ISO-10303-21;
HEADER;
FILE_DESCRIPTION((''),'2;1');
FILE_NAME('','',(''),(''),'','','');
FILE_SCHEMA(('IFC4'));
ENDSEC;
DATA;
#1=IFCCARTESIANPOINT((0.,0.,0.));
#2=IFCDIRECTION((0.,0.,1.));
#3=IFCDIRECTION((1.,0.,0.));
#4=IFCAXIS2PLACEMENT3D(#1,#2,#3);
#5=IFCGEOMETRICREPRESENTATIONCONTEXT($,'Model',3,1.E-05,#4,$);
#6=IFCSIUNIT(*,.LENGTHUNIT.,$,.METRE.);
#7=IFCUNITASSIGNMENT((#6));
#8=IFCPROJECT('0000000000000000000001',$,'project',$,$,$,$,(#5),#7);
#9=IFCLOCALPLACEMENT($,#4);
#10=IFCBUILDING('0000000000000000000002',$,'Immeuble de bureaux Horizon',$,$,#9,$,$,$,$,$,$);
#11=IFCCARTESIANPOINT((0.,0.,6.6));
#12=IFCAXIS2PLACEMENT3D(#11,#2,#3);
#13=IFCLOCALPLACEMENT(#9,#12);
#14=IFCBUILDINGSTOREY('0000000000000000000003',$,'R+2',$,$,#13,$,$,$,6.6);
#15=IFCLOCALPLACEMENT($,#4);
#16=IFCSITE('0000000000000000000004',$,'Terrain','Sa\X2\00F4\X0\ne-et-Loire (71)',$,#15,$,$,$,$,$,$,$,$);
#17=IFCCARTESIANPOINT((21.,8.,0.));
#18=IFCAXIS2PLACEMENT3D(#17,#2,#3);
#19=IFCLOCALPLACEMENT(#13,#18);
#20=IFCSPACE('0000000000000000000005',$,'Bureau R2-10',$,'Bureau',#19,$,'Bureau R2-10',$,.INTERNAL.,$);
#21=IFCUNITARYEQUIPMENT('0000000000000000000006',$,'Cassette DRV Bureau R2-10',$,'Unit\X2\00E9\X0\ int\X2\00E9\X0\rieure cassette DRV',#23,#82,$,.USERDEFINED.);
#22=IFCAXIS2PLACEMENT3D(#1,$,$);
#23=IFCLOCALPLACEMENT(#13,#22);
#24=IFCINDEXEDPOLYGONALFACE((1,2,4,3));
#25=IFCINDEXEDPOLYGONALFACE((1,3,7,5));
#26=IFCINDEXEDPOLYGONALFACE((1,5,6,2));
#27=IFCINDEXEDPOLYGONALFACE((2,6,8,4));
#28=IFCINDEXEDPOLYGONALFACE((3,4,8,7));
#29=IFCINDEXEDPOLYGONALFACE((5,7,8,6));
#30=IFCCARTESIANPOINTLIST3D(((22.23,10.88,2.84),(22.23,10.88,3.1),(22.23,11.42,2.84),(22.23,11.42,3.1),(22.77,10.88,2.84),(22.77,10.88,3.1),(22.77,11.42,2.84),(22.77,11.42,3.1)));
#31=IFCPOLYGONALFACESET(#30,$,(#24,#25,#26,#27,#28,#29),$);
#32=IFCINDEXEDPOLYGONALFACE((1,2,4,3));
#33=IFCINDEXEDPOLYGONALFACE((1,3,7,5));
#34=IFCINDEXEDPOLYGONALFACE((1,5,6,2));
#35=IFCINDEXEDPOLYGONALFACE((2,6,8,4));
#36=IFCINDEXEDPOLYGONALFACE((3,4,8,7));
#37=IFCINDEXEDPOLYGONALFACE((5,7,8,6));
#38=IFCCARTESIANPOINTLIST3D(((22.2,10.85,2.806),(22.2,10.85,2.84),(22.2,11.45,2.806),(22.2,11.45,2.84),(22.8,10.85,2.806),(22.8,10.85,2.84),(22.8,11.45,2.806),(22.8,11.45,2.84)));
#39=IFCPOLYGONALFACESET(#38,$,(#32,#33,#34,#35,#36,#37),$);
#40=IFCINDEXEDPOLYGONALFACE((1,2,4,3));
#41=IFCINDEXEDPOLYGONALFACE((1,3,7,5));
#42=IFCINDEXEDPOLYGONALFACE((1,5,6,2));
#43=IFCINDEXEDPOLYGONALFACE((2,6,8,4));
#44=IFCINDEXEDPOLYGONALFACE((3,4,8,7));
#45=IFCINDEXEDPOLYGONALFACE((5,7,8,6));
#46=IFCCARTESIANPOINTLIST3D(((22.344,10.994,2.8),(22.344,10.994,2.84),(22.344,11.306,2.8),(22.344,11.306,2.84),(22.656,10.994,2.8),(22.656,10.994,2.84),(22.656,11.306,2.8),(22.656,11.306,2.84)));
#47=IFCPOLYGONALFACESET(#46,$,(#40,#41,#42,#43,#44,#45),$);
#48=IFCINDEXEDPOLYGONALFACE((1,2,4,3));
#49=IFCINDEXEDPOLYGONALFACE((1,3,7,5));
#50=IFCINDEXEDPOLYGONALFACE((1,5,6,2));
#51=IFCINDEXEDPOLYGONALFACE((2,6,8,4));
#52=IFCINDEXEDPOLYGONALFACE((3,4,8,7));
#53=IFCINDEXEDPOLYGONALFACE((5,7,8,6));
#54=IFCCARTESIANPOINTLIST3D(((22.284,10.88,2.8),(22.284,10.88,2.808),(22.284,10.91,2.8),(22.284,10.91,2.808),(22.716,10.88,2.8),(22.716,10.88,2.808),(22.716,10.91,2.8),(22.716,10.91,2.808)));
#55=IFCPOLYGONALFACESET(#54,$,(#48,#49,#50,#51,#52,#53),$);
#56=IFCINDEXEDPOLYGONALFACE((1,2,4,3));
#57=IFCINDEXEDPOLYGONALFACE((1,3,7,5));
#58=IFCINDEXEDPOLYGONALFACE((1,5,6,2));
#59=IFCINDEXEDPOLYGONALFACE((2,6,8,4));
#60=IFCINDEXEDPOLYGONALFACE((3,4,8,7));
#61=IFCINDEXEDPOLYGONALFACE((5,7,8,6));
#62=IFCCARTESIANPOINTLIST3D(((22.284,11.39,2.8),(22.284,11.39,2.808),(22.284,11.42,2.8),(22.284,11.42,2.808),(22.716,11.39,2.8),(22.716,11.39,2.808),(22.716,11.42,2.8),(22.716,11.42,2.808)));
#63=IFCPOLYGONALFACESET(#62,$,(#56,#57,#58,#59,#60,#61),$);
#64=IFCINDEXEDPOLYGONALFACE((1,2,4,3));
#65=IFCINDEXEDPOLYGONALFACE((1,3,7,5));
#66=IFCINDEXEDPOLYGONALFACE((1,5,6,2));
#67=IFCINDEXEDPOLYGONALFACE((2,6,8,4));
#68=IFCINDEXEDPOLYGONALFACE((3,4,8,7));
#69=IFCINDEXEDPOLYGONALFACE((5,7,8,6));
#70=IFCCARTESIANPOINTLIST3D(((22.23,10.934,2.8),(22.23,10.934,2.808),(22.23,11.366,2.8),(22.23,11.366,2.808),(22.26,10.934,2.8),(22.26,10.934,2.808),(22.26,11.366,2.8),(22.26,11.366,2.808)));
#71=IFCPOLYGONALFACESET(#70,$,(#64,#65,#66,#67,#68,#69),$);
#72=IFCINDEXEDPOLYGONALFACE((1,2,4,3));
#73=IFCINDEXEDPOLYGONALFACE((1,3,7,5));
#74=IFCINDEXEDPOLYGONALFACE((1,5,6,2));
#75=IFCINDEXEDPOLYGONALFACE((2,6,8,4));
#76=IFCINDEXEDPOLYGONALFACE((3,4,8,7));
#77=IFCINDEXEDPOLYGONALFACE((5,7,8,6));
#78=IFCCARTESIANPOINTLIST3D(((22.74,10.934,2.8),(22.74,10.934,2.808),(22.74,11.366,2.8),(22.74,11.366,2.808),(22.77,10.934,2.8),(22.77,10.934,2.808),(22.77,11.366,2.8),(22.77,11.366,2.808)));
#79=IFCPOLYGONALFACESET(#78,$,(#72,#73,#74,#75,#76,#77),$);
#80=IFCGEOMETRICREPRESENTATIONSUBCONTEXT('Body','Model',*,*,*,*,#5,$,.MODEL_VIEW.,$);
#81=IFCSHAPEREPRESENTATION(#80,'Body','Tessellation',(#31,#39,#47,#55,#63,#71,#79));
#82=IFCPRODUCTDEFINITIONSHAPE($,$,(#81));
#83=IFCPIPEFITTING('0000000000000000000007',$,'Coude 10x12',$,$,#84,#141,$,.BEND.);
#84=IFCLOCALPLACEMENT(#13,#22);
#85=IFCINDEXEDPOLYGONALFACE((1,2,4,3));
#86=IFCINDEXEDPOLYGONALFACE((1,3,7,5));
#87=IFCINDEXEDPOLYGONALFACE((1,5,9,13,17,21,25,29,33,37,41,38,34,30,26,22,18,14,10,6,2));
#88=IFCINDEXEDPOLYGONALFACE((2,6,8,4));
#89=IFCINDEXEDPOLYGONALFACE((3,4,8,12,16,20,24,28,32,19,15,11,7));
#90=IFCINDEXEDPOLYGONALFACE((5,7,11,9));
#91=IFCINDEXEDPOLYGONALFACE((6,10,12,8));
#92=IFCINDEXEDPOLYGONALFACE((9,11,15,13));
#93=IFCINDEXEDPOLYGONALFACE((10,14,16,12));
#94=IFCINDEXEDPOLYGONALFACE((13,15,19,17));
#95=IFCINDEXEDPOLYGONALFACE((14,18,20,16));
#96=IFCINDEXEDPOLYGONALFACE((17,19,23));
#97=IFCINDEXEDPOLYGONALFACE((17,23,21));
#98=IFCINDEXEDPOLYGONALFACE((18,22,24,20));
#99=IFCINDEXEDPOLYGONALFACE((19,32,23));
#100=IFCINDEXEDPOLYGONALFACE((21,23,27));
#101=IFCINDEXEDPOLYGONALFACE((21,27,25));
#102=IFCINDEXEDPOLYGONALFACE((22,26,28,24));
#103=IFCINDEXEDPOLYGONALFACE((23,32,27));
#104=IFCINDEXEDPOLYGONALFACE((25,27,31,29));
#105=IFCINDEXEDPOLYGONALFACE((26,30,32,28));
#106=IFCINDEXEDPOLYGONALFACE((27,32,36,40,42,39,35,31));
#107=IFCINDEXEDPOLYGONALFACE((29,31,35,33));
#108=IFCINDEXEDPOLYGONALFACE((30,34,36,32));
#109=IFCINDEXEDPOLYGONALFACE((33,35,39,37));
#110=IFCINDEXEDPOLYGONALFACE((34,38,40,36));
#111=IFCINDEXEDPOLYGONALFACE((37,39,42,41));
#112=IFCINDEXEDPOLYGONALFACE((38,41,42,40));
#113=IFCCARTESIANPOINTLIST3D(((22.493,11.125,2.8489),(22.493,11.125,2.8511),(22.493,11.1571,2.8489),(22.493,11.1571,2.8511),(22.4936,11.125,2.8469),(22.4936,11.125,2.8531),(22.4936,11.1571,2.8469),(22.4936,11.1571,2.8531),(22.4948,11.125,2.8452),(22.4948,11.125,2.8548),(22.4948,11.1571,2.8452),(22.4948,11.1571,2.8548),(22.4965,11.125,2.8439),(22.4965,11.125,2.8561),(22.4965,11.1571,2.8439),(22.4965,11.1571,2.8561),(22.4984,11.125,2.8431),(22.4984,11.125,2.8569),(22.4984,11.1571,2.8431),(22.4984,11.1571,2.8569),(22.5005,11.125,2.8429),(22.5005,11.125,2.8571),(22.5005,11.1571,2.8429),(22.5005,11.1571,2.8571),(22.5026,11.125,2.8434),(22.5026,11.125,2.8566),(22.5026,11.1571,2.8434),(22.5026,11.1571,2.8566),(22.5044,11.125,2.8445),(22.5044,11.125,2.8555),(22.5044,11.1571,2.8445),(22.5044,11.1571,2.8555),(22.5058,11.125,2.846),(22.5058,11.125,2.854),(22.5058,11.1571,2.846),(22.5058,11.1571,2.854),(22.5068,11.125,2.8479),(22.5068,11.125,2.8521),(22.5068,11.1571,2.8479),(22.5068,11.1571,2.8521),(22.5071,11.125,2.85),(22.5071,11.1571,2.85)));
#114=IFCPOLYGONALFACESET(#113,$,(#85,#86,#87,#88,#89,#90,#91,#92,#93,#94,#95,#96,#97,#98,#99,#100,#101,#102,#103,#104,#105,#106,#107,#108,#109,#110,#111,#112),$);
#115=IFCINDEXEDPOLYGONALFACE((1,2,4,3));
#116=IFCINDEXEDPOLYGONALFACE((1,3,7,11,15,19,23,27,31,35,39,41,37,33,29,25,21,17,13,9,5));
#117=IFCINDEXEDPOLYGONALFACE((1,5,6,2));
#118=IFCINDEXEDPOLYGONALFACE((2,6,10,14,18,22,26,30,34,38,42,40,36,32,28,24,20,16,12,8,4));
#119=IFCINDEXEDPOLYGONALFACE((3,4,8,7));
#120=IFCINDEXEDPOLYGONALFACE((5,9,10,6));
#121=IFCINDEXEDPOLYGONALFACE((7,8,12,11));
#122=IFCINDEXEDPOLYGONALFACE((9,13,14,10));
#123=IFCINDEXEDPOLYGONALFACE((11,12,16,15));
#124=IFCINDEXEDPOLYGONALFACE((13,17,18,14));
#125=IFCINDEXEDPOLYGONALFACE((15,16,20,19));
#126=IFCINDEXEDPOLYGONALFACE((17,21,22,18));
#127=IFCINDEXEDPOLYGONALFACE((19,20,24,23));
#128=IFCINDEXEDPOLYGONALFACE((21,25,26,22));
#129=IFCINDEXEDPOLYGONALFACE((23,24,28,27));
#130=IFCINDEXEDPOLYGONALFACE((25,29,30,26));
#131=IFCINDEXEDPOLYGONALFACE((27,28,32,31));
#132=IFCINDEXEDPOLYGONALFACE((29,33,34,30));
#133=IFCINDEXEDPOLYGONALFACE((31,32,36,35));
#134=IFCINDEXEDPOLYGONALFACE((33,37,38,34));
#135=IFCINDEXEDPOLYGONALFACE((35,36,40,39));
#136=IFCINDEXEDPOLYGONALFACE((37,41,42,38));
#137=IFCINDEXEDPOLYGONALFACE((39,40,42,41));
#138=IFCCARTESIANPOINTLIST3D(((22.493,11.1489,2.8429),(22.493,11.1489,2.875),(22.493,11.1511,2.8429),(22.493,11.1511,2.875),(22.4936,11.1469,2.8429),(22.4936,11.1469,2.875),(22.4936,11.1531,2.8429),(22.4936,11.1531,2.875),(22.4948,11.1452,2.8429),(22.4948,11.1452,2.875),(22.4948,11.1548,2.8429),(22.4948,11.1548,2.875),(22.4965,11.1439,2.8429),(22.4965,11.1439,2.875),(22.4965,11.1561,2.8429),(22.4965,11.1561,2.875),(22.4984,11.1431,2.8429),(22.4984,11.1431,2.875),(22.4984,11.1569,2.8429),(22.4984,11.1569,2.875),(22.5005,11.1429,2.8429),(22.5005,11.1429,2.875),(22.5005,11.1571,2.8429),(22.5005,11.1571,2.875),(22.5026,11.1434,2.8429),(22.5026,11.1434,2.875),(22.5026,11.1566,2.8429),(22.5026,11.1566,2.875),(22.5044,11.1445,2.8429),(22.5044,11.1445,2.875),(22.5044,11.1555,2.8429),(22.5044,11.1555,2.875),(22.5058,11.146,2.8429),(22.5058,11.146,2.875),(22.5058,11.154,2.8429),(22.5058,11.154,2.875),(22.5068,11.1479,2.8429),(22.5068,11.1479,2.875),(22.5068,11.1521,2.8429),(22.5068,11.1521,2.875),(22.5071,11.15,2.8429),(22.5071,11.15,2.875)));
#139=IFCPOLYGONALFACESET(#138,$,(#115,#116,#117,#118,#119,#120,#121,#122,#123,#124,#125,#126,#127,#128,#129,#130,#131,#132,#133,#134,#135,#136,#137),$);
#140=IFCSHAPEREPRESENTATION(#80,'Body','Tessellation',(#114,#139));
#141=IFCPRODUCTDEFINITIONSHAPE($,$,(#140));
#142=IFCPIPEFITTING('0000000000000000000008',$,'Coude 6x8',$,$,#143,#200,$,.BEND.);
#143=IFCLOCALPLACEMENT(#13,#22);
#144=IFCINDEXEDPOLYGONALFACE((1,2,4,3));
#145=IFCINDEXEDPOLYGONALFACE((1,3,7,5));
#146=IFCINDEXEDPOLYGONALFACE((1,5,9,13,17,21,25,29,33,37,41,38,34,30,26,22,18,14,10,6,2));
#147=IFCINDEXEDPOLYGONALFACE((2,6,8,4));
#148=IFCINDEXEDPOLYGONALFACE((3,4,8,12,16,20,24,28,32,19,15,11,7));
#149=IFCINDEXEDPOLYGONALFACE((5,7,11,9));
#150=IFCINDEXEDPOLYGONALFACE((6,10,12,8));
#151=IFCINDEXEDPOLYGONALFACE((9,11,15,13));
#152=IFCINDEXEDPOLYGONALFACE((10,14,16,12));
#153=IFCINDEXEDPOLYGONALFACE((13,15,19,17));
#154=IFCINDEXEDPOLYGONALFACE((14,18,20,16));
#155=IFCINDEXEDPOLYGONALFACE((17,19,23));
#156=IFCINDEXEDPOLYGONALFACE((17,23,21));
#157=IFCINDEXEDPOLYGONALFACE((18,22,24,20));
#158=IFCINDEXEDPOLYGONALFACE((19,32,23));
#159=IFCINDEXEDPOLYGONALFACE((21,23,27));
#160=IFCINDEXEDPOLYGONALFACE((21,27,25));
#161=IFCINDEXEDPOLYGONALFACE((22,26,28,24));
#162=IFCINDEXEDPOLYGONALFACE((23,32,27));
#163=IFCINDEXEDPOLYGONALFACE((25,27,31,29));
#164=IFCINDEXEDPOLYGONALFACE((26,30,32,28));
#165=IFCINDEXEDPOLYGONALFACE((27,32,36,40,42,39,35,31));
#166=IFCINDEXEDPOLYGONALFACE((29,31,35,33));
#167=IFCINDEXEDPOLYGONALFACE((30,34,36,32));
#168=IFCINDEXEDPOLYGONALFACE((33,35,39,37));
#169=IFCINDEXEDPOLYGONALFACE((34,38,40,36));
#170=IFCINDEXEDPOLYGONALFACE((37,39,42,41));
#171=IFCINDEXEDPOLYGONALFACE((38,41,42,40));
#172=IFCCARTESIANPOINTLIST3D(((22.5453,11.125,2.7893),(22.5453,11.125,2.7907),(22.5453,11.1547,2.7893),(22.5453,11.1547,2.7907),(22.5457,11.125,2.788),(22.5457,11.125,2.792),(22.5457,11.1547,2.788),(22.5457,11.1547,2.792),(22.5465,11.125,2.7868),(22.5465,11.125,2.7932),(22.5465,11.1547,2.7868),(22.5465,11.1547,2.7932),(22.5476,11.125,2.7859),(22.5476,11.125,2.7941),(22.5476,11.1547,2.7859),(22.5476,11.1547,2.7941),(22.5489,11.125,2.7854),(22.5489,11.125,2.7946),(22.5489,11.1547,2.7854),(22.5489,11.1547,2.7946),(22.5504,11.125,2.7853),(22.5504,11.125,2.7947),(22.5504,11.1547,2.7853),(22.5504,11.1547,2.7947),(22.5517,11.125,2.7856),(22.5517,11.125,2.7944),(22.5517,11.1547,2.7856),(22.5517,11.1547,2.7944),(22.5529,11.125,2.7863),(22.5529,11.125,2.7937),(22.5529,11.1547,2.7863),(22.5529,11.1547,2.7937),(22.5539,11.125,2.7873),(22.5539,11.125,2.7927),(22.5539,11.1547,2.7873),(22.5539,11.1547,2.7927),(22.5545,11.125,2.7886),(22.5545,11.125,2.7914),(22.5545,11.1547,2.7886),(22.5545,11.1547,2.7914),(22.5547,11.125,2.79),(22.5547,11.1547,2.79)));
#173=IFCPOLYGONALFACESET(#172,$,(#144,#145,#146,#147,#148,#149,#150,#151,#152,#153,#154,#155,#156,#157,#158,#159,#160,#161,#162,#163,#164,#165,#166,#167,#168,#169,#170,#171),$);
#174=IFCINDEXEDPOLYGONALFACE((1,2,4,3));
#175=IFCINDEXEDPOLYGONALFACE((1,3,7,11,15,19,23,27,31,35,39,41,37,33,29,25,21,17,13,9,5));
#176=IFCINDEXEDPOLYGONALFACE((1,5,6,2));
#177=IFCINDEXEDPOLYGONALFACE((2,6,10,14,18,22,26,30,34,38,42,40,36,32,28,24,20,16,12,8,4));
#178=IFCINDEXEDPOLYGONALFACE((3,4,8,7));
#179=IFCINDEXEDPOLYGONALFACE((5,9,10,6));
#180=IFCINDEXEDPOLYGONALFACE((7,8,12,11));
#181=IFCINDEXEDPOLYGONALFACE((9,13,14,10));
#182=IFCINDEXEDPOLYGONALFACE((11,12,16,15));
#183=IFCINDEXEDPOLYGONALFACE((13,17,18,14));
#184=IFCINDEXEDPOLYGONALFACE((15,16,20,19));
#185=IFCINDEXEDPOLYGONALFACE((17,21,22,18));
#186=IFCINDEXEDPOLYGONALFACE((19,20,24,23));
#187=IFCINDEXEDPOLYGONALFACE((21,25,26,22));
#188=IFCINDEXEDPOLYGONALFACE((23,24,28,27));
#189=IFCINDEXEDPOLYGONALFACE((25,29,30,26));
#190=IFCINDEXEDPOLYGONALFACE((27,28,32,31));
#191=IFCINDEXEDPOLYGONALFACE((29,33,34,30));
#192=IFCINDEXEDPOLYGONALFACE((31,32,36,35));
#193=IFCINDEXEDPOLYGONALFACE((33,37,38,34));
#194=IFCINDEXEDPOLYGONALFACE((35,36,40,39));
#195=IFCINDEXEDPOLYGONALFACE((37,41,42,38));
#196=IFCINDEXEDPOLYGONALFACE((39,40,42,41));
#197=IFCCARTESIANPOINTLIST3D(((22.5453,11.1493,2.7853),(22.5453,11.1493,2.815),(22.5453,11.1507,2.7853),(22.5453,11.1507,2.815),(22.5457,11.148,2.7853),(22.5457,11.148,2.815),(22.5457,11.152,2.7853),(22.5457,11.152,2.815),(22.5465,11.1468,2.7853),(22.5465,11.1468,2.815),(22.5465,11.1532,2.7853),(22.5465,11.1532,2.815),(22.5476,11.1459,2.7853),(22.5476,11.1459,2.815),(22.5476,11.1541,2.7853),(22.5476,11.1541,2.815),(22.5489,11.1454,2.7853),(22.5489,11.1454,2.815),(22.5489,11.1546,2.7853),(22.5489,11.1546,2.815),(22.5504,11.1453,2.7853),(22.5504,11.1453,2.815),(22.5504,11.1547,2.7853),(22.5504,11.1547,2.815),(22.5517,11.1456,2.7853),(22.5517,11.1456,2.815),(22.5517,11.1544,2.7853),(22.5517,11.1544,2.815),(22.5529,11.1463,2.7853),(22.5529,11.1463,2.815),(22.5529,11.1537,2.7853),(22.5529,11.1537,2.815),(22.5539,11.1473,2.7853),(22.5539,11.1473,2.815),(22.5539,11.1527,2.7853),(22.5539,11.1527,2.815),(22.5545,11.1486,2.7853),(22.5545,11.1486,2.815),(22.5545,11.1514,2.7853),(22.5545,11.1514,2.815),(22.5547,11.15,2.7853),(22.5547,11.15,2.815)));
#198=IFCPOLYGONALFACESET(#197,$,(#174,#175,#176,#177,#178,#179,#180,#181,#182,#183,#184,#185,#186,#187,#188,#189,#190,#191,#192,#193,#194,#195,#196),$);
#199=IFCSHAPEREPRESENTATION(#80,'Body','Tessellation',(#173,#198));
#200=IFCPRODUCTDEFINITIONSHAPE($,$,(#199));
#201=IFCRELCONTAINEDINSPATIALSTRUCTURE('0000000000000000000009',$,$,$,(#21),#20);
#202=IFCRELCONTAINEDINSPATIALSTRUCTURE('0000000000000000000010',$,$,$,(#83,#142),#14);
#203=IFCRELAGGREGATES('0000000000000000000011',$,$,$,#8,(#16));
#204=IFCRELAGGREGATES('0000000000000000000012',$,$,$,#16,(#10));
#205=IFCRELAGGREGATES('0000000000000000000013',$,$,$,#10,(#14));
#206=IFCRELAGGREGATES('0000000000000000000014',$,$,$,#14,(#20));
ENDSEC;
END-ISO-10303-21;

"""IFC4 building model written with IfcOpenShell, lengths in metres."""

from ifc_helpers import new_model, si_unit, frame, frame_2d, origin_with_axes, place, context, subcontext, project, spatial, rectangle, circle, extrude, element, save


model = new_model("IFC4")

# Units and contexts
model_context = context("Model", 3, precision=1e-05, world=origin_with_axes())
body_context = subcontext(model_context, "Body", "Model", "MODEL_VIEW")
ifc_project = project(units=[si_unit("LENGTHUNIT", "METRE")], contexts=[model_context])

# Site, building, storey
site_placement = place(None, origin_with_axes())
site = spatial("IfcSite", under=ifc_project, at=site_placement, Name="Terrain", Description="Saône-et-Loire (71)")
building_placement = place(None, origin_with_axes())
building = spatial("IfcBuilding", under=site, at=building_placement, Name="Immeuble de bureaux Horizon")
storey_placement = place(building_placement, frame((0.0, 0.0, 6.6), z_axis=(0.0, 0.0, 1.0), x_axis=(1.0, 0.0, 0.0)))
storey = spatial("IfcBuildingStorey", under=building, at=storey_placement, Name="R+2", Elevation=6.6)

# Shared definitions
space_1_placement = place(storey_placement, frame((21.0, 8.0, 0.0), z_axis=(0.0, 0.0, 1.0), x_axis=(1.0, 0.0, 0.0)))
space_1 = spatial("IfcSpace", under=storey, at=space_1_placement, Name="Bureau R2-10", ObjectType="Bureau", LongName="Bureau R2-10", PredefinedType="INTERNAL")

# Unitary equipment
unitary_equipment_1_placement = place(space_1_placement, frame((1.2, 2.85, 2.8), z_axis=(0.0, 0.0, 1.0), x_axis=(1.0, 0.0, 0.0)))
element("IfcUnitaryEquipment", 1, at=unitary_equipment_1_placement, inside=space_1, Name="Cassette DRV Bureau R2-10", ObjectType="Unité intérieure cassette DRV", PredefinedType="USERDEFINED", context=body_context, shape_type="SweptSolid", body=[
    extrude(rectangle(XDim=0.54, YDim=0.54, at=frame_2d((0.27, 0.27))), frame((0.03, 0.03, 0.04), z_axis=(0.0, 0.0, 1.0), x_axis=(1.0, 0.0, 0.0)), (0.0, 0.0, 1.0), 0.26),
    extrude(rectangle(XDim=0.6, YDim=0.6, at=frame_2d((0.3, 0.3))), frame((0.0, 0.0, 0.006), z_axis=(0.0, 0.0, 1.0), x_axis=(1.0, 0.0, 0.0)), (0.0, 0.0, 1.0), 0.034),
    extrude(rectangle(XDim=0.312, YDim=0.312, at=frame_2d((0.156, 0.156))), frame((0.144, 0.144, 0.0), z_axis=(0.0, 0.0, 1.0), x_axis=(1.0, 0.0, 0.0)), (0.0, 0.0, 1.0), 0.04),
    extrude(rectangle(XDim=0.432, YDim=0.03, at=frame_2d((0.216, 0.015))), frame((0.084, 0.03, 0.0), z_axis=(0.0, 0.0, 1.0), x_axis=(1.0, 0.0, 0.0)), (0.0, 0.0, 1.0), 0.008),
    extrude(rectangle(XDim=0.432, YDim=0.03, at=frame_2d((0.216, 0.015))), frame((0.084, 0.54, 0.0), z_axis=(0.0, 0.0, 1.0), x_axis=(1.0, 0.0, 0.0)), (0.0, 0.0, 1.0), 0.008),
    extrude(rectangle(XDim=0.03, YDim=0.432, at=frame_2d((0.015, 0.216))), frame((0.03, 0.084, 0.0), z_axis=(0.0, 0.0, 1.0), x_axis=(1.0, 0.0, 0.0)), (0.0, 0.0, 1.0), 0.008),
    extrude(rectangle(XDim=0.03, YDim=0.432, at=frame_2d((0.015, 0.216))), frame((0.54, 0.084, 0.0), z_axis=(0.0, 0.0, 1.0), x_axis=(1.0, 0.0, 0.0)), (0.0, 0.0, 1.0), 0.008),
])

# Pipe fittings
pipe_fitting_1_placement = place(storey_placement, frame((22.5, 11.15, 2.85), z_axis=(0.0, 0.0, 1.0), x_axis=(1.0, 0.0, 0.0)))
element("IfcPipeFitting", 2, at=pipe_fitting_1_placement, inside=storey, Name="Coude 10x12", PredefinedType="BEND", context=body_context, shape_type="SweptSolid", body=[
    extrude(circle(Radius=0.0071), frame((0.0, 0.0071, 0.0), z_axis=(0.0, -1.0, 0.0), x_axis=(1.0, 0.0, 0.0)), (0.0, 0.0, 1.0), 0.0321),
    extrude(circle(Radius=0.0071), frame((0.0, 0.0, -0.0071), z_axis=(0.0, 0.0, 1.0), x_axis=(1.0, 0.0, 0.0)), (0.0, 0.0, 1.0), 0.0321),
])
pipe_fitting_2_placement = place(storey_placement, frame((22.55, 11.15, 2.79), z_axis=(0.0, 0.0, 1.0), x_axis=(1.0, 0.0, 0.0)))
element("IfcPipeFitting", 3, at=pipe_fitting_2_placement, inside=storey, Name="Coude 6x8", PredefinedType="BEND", context=body_context, shape_type="SweptSolid", body=[
    extrude(circle(Radius=0.0047), frame((0.0, 0.0047, 0.0), z_axis=(0.0, -1.0, 0.0), x_axis=(1.0, 0.0, 0.0)), (0.0, 0.0, 1.0), 0.0297),
    extrude(circle(Radius=0.0047), frame((0.0, 0.0, -0.0047), z_axis=(0.0, 0.0, 1.0), x_axis=(1.0, 0.0, 0.0)), (0.0, 0.0, 1.0), 0.0297),
])

save(model, "model.ifc")
